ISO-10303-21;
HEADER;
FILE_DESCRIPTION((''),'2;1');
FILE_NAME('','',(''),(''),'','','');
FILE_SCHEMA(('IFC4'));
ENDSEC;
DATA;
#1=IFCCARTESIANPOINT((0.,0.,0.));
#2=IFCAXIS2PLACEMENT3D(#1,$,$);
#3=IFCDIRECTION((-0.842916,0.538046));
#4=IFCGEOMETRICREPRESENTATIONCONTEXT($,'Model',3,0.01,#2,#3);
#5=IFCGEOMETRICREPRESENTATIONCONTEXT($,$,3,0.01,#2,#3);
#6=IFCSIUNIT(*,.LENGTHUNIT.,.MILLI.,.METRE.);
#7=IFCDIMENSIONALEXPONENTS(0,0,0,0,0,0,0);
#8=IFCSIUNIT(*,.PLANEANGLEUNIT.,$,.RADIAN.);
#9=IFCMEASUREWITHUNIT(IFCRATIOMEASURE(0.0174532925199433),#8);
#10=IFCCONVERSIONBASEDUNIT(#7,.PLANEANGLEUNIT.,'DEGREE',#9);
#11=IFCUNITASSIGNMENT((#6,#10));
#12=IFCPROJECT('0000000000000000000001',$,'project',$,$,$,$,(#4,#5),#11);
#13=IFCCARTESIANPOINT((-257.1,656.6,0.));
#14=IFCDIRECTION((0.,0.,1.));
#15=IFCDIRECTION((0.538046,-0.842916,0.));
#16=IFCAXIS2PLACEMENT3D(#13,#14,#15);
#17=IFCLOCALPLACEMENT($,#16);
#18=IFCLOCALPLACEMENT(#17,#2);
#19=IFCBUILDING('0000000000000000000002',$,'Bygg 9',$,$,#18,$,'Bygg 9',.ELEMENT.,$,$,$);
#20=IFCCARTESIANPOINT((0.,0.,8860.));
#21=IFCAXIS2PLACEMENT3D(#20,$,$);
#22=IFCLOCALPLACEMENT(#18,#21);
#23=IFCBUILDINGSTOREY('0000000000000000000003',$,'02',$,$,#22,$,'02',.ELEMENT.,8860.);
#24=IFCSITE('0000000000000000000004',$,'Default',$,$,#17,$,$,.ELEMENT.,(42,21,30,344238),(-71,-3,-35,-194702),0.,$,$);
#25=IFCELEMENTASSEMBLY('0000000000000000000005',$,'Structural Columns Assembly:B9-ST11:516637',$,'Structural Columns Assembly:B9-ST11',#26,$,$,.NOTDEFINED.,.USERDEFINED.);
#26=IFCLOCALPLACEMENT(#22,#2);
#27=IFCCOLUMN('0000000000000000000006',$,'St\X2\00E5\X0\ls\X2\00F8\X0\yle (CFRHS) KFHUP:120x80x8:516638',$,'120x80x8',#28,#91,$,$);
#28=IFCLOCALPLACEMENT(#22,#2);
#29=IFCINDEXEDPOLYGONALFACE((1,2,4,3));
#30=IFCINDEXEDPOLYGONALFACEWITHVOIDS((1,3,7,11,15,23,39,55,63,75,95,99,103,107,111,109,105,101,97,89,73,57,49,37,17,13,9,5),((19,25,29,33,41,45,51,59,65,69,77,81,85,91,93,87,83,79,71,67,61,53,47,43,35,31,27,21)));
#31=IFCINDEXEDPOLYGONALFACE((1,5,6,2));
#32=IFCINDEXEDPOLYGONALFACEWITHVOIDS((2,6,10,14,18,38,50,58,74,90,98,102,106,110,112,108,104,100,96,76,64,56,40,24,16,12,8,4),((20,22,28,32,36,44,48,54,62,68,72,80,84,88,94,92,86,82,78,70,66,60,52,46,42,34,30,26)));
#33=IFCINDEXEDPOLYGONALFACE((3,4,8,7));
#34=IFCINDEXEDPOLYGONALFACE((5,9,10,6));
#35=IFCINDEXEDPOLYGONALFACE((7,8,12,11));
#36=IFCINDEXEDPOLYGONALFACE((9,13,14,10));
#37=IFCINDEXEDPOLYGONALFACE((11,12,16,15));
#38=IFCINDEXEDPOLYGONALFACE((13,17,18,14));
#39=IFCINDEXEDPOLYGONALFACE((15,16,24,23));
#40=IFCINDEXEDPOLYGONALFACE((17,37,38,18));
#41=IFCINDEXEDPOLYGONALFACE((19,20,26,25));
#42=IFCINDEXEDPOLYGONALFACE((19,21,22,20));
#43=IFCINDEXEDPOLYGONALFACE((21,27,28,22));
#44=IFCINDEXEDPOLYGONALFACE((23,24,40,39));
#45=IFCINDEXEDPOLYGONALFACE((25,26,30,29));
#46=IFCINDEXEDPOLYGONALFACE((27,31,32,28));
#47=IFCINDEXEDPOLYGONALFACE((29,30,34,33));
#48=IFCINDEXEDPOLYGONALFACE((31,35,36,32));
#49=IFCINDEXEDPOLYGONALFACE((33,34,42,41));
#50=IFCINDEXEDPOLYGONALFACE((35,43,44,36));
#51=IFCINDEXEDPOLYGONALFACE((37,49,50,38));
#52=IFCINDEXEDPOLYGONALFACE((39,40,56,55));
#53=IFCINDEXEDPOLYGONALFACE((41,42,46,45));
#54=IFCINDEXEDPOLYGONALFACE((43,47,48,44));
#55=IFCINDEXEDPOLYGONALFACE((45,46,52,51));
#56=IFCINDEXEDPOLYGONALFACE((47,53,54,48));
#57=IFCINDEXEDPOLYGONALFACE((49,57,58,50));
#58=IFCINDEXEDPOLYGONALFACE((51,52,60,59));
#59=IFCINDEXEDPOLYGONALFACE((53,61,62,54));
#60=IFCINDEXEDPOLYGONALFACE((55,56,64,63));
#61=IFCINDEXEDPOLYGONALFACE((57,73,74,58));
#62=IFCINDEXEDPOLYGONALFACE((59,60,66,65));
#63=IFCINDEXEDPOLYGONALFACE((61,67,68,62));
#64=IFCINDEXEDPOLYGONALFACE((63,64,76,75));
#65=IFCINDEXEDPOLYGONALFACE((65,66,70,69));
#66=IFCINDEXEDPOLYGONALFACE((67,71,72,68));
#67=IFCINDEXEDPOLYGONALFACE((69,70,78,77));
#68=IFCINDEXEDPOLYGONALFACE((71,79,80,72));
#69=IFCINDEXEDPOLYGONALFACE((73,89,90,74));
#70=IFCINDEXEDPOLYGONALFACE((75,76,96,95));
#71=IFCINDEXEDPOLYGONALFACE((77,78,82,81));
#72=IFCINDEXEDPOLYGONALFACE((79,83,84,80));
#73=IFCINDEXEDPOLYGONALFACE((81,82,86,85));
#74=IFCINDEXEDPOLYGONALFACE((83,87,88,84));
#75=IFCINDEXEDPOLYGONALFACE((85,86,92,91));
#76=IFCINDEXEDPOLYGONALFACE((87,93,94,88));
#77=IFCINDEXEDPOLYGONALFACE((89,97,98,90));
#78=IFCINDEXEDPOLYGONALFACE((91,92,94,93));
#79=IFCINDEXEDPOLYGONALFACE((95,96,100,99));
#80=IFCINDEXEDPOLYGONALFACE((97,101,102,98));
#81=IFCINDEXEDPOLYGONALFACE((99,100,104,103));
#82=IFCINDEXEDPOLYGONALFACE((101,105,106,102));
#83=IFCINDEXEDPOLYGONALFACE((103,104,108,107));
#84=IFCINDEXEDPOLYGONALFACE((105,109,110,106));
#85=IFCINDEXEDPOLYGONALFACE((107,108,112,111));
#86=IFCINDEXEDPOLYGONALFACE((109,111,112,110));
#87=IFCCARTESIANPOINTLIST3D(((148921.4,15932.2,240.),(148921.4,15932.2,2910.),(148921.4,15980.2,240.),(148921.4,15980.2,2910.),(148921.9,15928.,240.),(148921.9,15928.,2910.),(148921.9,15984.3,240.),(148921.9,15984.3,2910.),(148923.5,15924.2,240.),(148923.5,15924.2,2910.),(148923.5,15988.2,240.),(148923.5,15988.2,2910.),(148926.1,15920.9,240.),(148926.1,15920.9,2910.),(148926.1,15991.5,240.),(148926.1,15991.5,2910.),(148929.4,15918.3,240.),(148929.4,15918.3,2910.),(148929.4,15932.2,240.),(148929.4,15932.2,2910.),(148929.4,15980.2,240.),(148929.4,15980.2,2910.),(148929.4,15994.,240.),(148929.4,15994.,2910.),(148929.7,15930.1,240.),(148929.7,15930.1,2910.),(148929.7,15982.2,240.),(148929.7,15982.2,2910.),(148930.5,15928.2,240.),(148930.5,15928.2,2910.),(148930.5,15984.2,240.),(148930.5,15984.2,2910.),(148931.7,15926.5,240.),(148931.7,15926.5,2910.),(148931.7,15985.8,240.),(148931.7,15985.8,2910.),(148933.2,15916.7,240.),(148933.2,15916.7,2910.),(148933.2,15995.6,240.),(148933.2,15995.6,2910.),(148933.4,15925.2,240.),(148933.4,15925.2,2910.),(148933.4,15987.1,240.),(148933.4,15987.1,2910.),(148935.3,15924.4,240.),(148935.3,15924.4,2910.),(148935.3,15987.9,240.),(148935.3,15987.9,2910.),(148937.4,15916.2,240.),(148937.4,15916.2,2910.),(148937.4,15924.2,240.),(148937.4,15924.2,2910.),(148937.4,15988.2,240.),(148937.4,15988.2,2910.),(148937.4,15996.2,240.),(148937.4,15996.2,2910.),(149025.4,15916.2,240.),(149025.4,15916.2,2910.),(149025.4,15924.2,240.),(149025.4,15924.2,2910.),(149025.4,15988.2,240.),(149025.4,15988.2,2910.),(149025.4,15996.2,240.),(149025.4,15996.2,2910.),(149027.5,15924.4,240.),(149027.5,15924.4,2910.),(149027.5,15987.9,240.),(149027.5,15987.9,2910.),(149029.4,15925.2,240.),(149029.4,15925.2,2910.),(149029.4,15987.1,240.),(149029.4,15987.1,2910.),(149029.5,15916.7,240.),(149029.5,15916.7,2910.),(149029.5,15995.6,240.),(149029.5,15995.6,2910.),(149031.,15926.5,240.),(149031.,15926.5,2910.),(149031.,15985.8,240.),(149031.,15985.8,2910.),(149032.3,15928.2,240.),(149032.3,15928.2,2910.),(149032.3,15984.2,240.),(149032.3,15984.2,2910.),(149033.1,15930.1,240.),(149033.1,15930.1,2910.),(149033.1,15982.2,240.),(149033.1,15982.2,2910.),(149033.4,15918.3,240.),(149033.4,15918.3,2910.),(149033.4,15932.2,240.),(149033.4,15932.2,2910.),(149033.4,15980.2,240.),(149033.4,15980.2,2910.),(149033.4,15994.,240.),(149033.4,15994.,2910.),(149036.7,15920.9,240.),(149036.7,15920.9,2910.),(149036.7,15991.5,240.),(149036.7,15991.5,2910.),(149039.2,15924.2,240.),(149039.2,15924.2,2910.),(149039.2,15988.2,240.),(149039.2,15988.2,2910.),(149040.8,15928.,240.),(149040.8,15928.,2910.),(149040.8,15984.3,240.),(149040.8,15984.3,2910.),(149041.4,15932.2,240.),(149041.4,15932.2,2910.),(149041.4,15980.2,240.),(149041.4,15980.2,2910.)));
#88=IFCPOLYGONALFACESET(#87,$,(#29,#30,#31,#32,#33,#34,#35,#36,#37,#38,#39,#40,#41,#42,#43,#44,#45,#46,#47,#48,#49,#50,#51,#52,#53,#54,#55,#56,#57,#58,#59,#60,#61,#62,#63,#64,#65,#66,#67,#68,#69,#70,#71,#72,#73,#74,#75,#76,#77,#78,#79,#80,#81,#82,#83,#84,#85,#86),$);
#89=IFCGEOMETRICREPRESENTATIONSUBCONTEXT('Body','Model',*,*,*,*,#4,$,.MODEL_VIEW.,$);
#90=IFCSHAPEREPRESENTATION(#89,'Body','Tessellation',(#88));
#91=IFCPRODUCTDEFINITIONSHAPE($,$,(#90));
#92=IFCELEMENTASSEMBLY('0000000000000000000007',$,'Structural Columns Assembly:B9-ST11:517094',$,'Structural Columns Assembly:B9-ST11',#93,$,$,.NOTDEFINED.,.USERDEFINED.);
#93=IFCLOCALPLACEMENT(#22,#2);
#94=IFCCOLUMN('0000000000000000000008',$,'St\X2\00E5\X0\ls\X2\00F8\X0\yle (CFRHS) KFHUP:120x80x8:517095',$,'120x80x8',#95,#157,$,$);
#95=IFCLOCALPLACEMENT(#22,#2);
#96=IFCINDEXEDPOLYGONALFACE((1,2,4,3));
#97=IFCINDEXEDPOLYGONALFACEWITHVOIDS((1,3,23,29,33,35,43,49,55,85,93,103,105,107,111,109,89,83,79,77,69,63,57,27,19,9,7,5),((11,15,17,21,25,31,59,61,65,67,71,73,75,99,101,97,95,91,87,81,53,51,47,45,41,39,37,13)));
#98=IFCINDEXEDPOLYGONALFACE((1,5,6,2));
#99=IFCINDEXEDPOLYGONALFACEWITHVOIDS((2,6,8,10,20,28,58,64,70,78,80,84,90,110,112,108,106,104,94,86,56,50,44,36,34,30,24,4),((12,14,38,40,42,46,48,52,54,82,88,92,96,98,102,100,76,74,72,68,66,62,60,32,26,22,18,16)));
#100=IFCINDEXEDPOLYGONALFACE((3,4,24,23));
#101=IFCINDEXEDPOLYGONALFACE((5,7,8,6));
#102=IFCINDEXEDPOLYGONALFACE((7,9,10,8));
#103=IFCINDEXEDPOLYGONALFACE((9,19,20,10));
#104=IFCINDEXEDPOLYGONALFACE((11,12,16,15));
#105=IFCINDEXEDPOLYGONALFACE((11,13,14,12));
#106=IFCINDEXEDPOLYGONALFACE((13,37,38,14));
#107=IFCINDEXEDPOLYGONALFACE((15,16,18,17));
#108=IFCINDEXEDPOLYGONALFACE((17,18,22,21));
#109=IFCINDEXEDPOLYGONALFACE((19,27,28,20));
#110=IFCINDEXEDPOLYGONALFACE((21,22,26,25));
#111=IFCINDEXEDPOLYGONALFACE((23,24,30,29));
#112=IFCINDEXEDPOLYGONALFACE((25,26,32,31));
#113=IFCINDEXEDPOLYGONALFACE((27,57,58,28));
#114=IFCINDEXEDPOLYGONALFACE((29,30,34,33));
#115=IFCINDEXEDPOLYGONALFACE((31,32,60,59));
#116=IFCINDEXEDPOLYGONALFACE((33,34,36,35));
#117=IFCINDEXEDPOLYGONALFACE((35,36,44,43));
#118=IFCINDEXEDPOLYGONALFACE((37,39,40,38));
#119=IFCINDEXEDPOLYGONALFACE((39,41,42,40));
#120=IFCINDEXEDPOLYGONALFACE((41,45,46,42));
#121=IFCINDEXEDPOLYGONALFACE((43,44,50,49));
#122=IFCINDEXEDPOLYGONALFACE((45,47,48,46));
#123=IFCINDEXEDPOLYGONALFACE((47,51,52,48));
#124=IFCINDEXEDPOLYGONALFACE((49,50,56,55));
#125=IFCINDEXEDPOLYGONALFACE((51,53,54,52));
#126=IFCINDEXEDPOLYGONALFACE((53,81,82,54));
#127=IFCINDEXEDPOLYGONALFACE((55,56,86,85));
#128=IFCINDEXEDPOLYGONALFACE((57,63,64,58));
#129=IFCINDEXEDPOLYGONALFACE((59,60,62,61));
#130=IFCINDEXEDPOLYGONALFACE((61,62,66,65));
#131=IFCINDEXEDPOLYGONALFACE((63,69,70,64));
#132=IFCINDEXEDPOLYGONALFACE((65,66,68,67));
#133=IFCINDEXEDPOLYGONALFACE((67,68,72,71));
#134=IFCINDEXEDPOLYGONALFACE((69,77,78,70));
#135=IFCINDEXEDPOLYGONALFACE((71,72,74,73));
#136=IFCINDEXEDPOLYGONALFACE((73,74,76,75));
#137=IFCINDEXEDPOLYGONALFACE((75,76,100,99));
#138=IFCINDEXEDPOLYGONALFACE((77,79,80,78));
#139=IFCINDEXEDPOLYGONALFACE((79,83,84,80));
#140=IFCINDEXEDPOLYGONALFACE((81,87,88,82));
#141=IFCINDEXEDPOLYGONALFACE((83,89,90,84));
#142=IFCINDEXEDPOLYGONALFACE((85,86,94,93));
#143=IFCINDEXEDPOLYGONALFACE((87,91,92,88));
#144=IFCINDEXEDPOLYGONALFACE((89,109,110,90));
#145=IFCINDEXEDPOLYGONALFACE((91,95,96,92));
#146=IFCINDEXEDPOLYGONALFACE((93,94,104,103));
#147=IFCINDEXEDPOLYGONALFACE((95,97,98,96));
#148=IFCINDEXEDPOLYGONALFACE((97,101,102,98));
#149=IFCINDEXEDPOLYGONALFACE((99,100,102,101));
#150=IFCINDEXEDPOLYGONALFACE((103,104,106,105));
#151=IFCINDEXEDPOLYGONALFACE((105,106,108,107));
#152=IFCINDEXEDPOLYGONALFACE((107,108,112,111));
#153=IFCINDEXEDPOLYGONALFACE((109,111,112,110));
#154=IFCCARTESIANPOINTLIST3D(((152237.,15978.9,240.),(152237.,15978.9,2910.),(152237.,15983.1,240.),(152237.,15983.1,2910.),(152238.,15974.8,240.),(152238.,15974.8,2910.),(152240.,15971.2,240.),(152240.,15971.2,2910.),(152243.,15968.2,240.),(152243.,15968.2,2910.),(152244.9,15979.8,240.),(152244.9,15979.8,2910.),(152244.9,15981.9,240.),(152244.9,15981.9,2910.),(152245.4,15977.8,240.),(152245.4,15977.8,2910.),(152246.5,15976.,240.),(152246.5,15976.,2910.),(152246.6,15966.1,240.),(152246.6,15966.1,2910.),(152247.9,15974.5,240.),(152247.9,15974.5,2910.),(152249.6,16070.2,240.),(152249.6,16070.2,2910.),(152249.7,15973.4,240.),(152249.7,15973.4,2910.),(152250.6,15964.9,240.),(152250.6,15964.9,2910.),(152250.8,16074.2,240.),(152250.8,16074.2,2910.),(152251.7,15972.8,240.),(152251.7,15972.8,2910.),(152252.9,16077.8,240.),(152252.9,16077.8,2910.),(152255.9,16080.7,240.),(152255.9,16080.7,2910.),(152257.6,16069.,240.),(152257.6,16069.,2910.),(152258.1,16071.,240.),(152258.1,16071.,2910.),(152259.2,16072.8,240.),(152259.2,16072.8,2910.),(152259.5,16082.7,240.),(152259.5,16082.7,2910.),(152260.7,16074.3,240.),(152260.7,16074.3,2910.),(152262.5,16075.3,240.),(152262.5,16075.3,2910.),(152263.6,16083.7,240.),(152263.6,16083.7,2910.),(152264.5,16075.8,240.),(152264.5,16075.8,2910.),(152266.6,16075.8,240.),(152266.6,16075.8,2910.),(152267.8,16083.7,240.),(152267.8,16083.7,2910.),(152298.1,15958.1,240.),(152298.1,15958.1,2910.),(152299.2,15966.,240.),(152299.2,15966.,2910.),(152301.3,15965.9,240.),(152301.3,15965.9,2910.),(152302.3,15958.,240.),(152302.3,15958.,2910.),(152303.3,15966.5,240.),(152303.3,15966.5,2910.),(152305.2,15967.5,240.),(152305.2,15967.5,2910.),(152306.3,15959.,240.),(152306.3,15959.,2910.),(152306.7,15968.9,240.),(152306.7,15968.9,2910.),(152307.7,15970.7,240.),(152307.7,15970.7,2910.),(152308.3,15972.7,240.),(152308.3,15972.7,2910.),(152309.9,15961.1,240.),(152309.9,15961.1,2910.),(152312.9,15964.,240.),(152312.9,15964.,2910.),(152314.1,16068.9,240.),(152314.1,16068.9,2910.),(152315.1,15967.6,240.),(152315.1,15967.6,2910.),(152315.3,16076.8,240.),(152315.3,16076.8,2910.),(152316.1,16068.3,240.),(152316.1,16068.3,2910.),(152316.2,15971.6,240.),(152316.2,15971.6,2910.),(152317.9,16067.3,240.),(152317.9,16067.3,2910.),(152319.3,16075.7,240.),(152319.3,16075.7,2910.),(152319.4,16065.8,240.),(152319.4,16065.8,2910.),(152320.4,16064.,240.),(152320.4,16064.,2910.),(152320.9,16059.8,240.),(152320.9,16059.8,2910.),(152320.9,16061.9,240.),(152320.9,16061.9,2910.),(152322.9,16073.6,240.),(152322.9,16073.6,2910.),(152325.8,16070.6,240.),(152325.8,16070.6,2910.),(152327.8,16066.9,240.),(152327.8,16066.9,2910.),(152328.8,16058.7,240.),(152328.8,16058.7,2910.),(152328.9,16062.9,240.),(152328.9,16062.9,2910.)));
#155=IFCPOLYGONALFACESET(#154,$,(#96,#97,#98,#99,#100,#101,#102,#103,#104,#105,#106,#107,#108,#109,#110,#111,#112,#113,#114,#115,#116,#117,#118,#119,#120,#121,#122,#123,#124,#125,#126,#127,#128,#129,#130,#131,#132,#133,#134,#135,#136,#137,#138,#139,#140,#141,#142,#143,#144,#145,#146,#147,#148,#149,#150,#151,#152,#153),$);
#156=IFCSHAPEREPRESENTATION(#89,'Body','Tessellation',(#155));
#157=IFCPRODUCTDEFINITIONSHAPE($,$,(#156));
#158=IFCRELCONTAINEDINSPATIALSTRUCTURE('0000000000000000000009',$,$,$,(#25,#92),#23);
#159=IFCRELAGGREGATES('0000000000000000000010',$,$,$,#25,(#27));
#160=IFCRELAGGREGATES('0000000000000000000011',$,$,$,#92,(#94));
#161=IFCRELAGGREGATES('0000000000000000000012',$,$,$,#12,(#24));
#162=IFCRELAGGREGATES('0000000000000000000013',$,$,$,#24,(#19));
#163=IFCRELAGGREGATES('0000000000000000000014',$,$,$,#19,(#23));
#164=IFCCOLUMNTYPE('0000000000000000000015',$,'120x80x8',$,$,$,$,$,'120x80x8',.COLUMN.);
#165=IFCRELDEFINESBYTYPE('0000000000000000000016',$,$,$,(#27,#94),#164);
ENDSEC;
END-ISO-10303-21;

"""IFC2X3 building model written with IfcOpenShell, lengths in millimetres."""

from ifc_helpers import new_model, entity, si_unit, converted_unit, direction, frame, frame_2d, origin, place, context, subcontext, project, spatial, polyline, circle_curve, parameter, trimmed, segment, composite_curve, outline, extrude, source, transform, mapped, type_object, type_shapes, element, aggregate, save


model = new_model("IFC2X3")

# Units and contexts
model_context = context("Model", 3, precision=0.01, world=origin(), true_north=direction((-0.842916, 0.538046)))
context_of_model = context(None, 3, precision=0.01, world=origin(), true_north=direction((-0.842916, 0.538046)))
body_context = subcontext(model_context, "Body", "Model", "MODEL_VIEW")
ifc_project = project(units=[si_unit("LENGTHUNIT", "METRE", prefix="MILLI"), converted_unit("PLANEANGLEUNIT", "DEGREE", entity("IfcRatioMeasure", 0.0174532925199433), si_unit("PLANEANGLEUNIT", "RADIAN"), dimensions=[0, 0, 0, 0, 0, 0, 0])], contexts=[model_context, context_of_model])

# Site, building, storey
site_placement = place(None, frame((-257.1, 656.6, 0.0), z_axis=(0.0, 0.0, 1.0), x_axis=(0.538046, -0.842916, 0.0)))
site = spatial("IfcSite", under=ifc_project, at=site_placement, Name="Default", CompositionType="ELEMENT", RefLatitude=(42, 21, 30, 344238), RefLongitude=(-71, -3, -35, -194702), RefElevation=0.0)
building_placement = place(site_placement, origin())
building = spatial("IfcBuilding", under=site, at=building_placement, Name="Bygg 9", LongName="Bygg 9", CompositionType="ELEMENT")
storey_placement = place(building_placement, frame((0.0, 0.0, 8860.0)))
storey = spatial("IfcBuildingStorey", under=building, at=storey_placement, Name="02", LongName="02", CompositionType="ELEMENT", Elevation=8860.0)

# Element assemblies, columns
assembly_1_placement = place(storey_placement, origin())
assembly_1 = element("IfcElementAssembly", 1, at=assembly_1_placement, inside=storey, Name="Structural Columns Assembly:B9-ST11:516637", ObjectType="Structural Columns Assembly:B9-ST11", AssemblyPlace="NOTDEFINED", PredefinedType="USERDEFINED")
column_type = type_object("IfcColumnType", Name="120x80x8", ElementType="120x80x8", PredefinedType="COLUMN")
shared_shape_1 = source(origin(), body_context, "Body", "SweptSolid", [
    extrude(outline(composite_curve([segment(trimmed(circle_curve(frame_2d((-24.0, 44.0), x_axis=(1.0, 0.0)), 16.0), [parameter(90.0)], [parameter(180.0)], True, "PARAMETER"), True, "CONTINUOUS"), segment(polyline([(-40.0, 44.0), (-40.0, -44.0)]), True, "CONTINUOUS"), segment(trimmed(circle_curve(frame_2d((-24.0, -44.0), x_axis=(1.0, 0.0)), 16.0), [parameter(180.0)], [parameter(270.0)], True, "PARAMETER"), True, "CONTINUOUS"), segment(polyline([(-24.0, -60.0), (24.0, -60.0)]), True, "CONTINUOUS"), segment(trimmed(circle_curve(frame_2d((24.0, -44.0), x_axis=(1.0, 0.0)), 16.0), [parameter(270.0)], [parameter(0.0)], True, "PARAMETER"), True, "CONTINUOUS"), segment(polyline([(40.0, -44.0), (40.0, 44.0)]), True, "CONTINUOUS"), segment(trimmed(circle_curve(frame_2d((24.0, 44.0), x_axis=(1.0, 0.0)), 16.0), [parameter(0.0)], [parameter(90.0)], True, "PARAMETER"), True, "CONTINUOUS"), segment(polyline([(24.0, 60.0), (-24.0, 60.0)]), True, "CONTINUOUS")], self_intersect=False), holes=[composite_curve([segment(polyline([(-24.0, 52.0), (24.0, 52.0)]), True, "CONTINUOUS"), segment(trimmed(circle_curve(frame_2d((24.0, 44.0), x_axis=(1.0, 0.0)), 8.0), [parameter(360.0)], [parameter(90.0)], True, "PARAMETER"), False, "CONTINUOUS"), segment(polyline([(32.0, 44.0), (32.0, -44.0)]), True, "CONTINUOUS"), segment(trimmed(circle_curve(frame_2d((24.0, -44.0), x_axis=(1.0, 0.0)), 8.0), [parameter(270.0)], [parameter(360.0)], True, "PARAMETER"), False, "CONTINUOUS"), segment(polyline([(24.0, -52.0), (-24.0, -52.0)]), True, "CONTINUOUS"), segment(trimmed(circle_curve(frame_2d((-24.0, -44.0), x_axis=(1.0, 0.0)), 8.0), [parameter(180.0)], [parameter(270.0)], True, "PARAMETER"), False, "CONTINUOUS"), segment(polyline([(-32.0, -44.0), (-32.0, 44.0)]), True, "CONTINUOUS"), segment(trimmed(circle_curve(frame_2d((-24.0, 44.0), x_axis=(1.0, 0.0)), 8.0), [parameter(90.0)], [parameter(180.0)], True, "PARAMETER"), False, "CONTINUOUS")], self_intersect=False)]), frame((41.6, 61.6, 0.0), z_axis=(0.0, 0.0, 1.0), x_axis=(-1.0, 0.0, 0.0)), (0.0, 0.0, 1.0), 2670.0),
])
type_shapes(column_type, [shared_shape_1])
column_1_placement = place(assembly_1_placement, frame((149043.0, 15914.6, 240.0), z_axis=(0.0, 0.0, 1.0), x_axis=(0.0, 1.0, 0.0)))
column_1 = element("IfcColumn", 2, at=column_1_placement, type_object=column_type, Name="Stålsøyle (CFRHS) KFHUP:120x80x8:516638", ObjectType="120x80x8", context=body_context, shape_type="MappedRepresentation", body=[
    mapped(shared_shape_1, transform((0.0, 0.0, 0.0), scale=1.0)),
])
assembly_2_placement = place(storey_placement, origin())
assembly_2 = element("IfcElementAssembly", 3, at=assembly_2_placement, inside=storey, Name="Structural Columns Assembly:B9-ST11:517094", ObjectType="Structural Columns Assembly:B9-ST11", AssemblyPlace="NOTDEFINED", PredefinedType="USERDEFINED")
column_2_placement = place(assembly_2_placement, frame((152332.9, 16075.9, 240.0), z_axis=(0.0, 0.0, 1.0), x_axis=(-0.989691, 0.143216, 0.0)))
column_2 = element("IfcColumn", 4, at=column_2_placement, type_object=column_type, Name="Stålsøyle (CFRHS) KFHUP:120x80x8:517095", ObjectType="120x80x8", context=body_context, shape_type="MappedRepresentation", body=[
    mapped(shared_shape_1, transform((0.0, 0.0, 0.0), scale=1.0)),
])

aggregate(assembly_1, [column_1])
aggregate(assembly_2, [column_2])

save(model, "model.ifc")
